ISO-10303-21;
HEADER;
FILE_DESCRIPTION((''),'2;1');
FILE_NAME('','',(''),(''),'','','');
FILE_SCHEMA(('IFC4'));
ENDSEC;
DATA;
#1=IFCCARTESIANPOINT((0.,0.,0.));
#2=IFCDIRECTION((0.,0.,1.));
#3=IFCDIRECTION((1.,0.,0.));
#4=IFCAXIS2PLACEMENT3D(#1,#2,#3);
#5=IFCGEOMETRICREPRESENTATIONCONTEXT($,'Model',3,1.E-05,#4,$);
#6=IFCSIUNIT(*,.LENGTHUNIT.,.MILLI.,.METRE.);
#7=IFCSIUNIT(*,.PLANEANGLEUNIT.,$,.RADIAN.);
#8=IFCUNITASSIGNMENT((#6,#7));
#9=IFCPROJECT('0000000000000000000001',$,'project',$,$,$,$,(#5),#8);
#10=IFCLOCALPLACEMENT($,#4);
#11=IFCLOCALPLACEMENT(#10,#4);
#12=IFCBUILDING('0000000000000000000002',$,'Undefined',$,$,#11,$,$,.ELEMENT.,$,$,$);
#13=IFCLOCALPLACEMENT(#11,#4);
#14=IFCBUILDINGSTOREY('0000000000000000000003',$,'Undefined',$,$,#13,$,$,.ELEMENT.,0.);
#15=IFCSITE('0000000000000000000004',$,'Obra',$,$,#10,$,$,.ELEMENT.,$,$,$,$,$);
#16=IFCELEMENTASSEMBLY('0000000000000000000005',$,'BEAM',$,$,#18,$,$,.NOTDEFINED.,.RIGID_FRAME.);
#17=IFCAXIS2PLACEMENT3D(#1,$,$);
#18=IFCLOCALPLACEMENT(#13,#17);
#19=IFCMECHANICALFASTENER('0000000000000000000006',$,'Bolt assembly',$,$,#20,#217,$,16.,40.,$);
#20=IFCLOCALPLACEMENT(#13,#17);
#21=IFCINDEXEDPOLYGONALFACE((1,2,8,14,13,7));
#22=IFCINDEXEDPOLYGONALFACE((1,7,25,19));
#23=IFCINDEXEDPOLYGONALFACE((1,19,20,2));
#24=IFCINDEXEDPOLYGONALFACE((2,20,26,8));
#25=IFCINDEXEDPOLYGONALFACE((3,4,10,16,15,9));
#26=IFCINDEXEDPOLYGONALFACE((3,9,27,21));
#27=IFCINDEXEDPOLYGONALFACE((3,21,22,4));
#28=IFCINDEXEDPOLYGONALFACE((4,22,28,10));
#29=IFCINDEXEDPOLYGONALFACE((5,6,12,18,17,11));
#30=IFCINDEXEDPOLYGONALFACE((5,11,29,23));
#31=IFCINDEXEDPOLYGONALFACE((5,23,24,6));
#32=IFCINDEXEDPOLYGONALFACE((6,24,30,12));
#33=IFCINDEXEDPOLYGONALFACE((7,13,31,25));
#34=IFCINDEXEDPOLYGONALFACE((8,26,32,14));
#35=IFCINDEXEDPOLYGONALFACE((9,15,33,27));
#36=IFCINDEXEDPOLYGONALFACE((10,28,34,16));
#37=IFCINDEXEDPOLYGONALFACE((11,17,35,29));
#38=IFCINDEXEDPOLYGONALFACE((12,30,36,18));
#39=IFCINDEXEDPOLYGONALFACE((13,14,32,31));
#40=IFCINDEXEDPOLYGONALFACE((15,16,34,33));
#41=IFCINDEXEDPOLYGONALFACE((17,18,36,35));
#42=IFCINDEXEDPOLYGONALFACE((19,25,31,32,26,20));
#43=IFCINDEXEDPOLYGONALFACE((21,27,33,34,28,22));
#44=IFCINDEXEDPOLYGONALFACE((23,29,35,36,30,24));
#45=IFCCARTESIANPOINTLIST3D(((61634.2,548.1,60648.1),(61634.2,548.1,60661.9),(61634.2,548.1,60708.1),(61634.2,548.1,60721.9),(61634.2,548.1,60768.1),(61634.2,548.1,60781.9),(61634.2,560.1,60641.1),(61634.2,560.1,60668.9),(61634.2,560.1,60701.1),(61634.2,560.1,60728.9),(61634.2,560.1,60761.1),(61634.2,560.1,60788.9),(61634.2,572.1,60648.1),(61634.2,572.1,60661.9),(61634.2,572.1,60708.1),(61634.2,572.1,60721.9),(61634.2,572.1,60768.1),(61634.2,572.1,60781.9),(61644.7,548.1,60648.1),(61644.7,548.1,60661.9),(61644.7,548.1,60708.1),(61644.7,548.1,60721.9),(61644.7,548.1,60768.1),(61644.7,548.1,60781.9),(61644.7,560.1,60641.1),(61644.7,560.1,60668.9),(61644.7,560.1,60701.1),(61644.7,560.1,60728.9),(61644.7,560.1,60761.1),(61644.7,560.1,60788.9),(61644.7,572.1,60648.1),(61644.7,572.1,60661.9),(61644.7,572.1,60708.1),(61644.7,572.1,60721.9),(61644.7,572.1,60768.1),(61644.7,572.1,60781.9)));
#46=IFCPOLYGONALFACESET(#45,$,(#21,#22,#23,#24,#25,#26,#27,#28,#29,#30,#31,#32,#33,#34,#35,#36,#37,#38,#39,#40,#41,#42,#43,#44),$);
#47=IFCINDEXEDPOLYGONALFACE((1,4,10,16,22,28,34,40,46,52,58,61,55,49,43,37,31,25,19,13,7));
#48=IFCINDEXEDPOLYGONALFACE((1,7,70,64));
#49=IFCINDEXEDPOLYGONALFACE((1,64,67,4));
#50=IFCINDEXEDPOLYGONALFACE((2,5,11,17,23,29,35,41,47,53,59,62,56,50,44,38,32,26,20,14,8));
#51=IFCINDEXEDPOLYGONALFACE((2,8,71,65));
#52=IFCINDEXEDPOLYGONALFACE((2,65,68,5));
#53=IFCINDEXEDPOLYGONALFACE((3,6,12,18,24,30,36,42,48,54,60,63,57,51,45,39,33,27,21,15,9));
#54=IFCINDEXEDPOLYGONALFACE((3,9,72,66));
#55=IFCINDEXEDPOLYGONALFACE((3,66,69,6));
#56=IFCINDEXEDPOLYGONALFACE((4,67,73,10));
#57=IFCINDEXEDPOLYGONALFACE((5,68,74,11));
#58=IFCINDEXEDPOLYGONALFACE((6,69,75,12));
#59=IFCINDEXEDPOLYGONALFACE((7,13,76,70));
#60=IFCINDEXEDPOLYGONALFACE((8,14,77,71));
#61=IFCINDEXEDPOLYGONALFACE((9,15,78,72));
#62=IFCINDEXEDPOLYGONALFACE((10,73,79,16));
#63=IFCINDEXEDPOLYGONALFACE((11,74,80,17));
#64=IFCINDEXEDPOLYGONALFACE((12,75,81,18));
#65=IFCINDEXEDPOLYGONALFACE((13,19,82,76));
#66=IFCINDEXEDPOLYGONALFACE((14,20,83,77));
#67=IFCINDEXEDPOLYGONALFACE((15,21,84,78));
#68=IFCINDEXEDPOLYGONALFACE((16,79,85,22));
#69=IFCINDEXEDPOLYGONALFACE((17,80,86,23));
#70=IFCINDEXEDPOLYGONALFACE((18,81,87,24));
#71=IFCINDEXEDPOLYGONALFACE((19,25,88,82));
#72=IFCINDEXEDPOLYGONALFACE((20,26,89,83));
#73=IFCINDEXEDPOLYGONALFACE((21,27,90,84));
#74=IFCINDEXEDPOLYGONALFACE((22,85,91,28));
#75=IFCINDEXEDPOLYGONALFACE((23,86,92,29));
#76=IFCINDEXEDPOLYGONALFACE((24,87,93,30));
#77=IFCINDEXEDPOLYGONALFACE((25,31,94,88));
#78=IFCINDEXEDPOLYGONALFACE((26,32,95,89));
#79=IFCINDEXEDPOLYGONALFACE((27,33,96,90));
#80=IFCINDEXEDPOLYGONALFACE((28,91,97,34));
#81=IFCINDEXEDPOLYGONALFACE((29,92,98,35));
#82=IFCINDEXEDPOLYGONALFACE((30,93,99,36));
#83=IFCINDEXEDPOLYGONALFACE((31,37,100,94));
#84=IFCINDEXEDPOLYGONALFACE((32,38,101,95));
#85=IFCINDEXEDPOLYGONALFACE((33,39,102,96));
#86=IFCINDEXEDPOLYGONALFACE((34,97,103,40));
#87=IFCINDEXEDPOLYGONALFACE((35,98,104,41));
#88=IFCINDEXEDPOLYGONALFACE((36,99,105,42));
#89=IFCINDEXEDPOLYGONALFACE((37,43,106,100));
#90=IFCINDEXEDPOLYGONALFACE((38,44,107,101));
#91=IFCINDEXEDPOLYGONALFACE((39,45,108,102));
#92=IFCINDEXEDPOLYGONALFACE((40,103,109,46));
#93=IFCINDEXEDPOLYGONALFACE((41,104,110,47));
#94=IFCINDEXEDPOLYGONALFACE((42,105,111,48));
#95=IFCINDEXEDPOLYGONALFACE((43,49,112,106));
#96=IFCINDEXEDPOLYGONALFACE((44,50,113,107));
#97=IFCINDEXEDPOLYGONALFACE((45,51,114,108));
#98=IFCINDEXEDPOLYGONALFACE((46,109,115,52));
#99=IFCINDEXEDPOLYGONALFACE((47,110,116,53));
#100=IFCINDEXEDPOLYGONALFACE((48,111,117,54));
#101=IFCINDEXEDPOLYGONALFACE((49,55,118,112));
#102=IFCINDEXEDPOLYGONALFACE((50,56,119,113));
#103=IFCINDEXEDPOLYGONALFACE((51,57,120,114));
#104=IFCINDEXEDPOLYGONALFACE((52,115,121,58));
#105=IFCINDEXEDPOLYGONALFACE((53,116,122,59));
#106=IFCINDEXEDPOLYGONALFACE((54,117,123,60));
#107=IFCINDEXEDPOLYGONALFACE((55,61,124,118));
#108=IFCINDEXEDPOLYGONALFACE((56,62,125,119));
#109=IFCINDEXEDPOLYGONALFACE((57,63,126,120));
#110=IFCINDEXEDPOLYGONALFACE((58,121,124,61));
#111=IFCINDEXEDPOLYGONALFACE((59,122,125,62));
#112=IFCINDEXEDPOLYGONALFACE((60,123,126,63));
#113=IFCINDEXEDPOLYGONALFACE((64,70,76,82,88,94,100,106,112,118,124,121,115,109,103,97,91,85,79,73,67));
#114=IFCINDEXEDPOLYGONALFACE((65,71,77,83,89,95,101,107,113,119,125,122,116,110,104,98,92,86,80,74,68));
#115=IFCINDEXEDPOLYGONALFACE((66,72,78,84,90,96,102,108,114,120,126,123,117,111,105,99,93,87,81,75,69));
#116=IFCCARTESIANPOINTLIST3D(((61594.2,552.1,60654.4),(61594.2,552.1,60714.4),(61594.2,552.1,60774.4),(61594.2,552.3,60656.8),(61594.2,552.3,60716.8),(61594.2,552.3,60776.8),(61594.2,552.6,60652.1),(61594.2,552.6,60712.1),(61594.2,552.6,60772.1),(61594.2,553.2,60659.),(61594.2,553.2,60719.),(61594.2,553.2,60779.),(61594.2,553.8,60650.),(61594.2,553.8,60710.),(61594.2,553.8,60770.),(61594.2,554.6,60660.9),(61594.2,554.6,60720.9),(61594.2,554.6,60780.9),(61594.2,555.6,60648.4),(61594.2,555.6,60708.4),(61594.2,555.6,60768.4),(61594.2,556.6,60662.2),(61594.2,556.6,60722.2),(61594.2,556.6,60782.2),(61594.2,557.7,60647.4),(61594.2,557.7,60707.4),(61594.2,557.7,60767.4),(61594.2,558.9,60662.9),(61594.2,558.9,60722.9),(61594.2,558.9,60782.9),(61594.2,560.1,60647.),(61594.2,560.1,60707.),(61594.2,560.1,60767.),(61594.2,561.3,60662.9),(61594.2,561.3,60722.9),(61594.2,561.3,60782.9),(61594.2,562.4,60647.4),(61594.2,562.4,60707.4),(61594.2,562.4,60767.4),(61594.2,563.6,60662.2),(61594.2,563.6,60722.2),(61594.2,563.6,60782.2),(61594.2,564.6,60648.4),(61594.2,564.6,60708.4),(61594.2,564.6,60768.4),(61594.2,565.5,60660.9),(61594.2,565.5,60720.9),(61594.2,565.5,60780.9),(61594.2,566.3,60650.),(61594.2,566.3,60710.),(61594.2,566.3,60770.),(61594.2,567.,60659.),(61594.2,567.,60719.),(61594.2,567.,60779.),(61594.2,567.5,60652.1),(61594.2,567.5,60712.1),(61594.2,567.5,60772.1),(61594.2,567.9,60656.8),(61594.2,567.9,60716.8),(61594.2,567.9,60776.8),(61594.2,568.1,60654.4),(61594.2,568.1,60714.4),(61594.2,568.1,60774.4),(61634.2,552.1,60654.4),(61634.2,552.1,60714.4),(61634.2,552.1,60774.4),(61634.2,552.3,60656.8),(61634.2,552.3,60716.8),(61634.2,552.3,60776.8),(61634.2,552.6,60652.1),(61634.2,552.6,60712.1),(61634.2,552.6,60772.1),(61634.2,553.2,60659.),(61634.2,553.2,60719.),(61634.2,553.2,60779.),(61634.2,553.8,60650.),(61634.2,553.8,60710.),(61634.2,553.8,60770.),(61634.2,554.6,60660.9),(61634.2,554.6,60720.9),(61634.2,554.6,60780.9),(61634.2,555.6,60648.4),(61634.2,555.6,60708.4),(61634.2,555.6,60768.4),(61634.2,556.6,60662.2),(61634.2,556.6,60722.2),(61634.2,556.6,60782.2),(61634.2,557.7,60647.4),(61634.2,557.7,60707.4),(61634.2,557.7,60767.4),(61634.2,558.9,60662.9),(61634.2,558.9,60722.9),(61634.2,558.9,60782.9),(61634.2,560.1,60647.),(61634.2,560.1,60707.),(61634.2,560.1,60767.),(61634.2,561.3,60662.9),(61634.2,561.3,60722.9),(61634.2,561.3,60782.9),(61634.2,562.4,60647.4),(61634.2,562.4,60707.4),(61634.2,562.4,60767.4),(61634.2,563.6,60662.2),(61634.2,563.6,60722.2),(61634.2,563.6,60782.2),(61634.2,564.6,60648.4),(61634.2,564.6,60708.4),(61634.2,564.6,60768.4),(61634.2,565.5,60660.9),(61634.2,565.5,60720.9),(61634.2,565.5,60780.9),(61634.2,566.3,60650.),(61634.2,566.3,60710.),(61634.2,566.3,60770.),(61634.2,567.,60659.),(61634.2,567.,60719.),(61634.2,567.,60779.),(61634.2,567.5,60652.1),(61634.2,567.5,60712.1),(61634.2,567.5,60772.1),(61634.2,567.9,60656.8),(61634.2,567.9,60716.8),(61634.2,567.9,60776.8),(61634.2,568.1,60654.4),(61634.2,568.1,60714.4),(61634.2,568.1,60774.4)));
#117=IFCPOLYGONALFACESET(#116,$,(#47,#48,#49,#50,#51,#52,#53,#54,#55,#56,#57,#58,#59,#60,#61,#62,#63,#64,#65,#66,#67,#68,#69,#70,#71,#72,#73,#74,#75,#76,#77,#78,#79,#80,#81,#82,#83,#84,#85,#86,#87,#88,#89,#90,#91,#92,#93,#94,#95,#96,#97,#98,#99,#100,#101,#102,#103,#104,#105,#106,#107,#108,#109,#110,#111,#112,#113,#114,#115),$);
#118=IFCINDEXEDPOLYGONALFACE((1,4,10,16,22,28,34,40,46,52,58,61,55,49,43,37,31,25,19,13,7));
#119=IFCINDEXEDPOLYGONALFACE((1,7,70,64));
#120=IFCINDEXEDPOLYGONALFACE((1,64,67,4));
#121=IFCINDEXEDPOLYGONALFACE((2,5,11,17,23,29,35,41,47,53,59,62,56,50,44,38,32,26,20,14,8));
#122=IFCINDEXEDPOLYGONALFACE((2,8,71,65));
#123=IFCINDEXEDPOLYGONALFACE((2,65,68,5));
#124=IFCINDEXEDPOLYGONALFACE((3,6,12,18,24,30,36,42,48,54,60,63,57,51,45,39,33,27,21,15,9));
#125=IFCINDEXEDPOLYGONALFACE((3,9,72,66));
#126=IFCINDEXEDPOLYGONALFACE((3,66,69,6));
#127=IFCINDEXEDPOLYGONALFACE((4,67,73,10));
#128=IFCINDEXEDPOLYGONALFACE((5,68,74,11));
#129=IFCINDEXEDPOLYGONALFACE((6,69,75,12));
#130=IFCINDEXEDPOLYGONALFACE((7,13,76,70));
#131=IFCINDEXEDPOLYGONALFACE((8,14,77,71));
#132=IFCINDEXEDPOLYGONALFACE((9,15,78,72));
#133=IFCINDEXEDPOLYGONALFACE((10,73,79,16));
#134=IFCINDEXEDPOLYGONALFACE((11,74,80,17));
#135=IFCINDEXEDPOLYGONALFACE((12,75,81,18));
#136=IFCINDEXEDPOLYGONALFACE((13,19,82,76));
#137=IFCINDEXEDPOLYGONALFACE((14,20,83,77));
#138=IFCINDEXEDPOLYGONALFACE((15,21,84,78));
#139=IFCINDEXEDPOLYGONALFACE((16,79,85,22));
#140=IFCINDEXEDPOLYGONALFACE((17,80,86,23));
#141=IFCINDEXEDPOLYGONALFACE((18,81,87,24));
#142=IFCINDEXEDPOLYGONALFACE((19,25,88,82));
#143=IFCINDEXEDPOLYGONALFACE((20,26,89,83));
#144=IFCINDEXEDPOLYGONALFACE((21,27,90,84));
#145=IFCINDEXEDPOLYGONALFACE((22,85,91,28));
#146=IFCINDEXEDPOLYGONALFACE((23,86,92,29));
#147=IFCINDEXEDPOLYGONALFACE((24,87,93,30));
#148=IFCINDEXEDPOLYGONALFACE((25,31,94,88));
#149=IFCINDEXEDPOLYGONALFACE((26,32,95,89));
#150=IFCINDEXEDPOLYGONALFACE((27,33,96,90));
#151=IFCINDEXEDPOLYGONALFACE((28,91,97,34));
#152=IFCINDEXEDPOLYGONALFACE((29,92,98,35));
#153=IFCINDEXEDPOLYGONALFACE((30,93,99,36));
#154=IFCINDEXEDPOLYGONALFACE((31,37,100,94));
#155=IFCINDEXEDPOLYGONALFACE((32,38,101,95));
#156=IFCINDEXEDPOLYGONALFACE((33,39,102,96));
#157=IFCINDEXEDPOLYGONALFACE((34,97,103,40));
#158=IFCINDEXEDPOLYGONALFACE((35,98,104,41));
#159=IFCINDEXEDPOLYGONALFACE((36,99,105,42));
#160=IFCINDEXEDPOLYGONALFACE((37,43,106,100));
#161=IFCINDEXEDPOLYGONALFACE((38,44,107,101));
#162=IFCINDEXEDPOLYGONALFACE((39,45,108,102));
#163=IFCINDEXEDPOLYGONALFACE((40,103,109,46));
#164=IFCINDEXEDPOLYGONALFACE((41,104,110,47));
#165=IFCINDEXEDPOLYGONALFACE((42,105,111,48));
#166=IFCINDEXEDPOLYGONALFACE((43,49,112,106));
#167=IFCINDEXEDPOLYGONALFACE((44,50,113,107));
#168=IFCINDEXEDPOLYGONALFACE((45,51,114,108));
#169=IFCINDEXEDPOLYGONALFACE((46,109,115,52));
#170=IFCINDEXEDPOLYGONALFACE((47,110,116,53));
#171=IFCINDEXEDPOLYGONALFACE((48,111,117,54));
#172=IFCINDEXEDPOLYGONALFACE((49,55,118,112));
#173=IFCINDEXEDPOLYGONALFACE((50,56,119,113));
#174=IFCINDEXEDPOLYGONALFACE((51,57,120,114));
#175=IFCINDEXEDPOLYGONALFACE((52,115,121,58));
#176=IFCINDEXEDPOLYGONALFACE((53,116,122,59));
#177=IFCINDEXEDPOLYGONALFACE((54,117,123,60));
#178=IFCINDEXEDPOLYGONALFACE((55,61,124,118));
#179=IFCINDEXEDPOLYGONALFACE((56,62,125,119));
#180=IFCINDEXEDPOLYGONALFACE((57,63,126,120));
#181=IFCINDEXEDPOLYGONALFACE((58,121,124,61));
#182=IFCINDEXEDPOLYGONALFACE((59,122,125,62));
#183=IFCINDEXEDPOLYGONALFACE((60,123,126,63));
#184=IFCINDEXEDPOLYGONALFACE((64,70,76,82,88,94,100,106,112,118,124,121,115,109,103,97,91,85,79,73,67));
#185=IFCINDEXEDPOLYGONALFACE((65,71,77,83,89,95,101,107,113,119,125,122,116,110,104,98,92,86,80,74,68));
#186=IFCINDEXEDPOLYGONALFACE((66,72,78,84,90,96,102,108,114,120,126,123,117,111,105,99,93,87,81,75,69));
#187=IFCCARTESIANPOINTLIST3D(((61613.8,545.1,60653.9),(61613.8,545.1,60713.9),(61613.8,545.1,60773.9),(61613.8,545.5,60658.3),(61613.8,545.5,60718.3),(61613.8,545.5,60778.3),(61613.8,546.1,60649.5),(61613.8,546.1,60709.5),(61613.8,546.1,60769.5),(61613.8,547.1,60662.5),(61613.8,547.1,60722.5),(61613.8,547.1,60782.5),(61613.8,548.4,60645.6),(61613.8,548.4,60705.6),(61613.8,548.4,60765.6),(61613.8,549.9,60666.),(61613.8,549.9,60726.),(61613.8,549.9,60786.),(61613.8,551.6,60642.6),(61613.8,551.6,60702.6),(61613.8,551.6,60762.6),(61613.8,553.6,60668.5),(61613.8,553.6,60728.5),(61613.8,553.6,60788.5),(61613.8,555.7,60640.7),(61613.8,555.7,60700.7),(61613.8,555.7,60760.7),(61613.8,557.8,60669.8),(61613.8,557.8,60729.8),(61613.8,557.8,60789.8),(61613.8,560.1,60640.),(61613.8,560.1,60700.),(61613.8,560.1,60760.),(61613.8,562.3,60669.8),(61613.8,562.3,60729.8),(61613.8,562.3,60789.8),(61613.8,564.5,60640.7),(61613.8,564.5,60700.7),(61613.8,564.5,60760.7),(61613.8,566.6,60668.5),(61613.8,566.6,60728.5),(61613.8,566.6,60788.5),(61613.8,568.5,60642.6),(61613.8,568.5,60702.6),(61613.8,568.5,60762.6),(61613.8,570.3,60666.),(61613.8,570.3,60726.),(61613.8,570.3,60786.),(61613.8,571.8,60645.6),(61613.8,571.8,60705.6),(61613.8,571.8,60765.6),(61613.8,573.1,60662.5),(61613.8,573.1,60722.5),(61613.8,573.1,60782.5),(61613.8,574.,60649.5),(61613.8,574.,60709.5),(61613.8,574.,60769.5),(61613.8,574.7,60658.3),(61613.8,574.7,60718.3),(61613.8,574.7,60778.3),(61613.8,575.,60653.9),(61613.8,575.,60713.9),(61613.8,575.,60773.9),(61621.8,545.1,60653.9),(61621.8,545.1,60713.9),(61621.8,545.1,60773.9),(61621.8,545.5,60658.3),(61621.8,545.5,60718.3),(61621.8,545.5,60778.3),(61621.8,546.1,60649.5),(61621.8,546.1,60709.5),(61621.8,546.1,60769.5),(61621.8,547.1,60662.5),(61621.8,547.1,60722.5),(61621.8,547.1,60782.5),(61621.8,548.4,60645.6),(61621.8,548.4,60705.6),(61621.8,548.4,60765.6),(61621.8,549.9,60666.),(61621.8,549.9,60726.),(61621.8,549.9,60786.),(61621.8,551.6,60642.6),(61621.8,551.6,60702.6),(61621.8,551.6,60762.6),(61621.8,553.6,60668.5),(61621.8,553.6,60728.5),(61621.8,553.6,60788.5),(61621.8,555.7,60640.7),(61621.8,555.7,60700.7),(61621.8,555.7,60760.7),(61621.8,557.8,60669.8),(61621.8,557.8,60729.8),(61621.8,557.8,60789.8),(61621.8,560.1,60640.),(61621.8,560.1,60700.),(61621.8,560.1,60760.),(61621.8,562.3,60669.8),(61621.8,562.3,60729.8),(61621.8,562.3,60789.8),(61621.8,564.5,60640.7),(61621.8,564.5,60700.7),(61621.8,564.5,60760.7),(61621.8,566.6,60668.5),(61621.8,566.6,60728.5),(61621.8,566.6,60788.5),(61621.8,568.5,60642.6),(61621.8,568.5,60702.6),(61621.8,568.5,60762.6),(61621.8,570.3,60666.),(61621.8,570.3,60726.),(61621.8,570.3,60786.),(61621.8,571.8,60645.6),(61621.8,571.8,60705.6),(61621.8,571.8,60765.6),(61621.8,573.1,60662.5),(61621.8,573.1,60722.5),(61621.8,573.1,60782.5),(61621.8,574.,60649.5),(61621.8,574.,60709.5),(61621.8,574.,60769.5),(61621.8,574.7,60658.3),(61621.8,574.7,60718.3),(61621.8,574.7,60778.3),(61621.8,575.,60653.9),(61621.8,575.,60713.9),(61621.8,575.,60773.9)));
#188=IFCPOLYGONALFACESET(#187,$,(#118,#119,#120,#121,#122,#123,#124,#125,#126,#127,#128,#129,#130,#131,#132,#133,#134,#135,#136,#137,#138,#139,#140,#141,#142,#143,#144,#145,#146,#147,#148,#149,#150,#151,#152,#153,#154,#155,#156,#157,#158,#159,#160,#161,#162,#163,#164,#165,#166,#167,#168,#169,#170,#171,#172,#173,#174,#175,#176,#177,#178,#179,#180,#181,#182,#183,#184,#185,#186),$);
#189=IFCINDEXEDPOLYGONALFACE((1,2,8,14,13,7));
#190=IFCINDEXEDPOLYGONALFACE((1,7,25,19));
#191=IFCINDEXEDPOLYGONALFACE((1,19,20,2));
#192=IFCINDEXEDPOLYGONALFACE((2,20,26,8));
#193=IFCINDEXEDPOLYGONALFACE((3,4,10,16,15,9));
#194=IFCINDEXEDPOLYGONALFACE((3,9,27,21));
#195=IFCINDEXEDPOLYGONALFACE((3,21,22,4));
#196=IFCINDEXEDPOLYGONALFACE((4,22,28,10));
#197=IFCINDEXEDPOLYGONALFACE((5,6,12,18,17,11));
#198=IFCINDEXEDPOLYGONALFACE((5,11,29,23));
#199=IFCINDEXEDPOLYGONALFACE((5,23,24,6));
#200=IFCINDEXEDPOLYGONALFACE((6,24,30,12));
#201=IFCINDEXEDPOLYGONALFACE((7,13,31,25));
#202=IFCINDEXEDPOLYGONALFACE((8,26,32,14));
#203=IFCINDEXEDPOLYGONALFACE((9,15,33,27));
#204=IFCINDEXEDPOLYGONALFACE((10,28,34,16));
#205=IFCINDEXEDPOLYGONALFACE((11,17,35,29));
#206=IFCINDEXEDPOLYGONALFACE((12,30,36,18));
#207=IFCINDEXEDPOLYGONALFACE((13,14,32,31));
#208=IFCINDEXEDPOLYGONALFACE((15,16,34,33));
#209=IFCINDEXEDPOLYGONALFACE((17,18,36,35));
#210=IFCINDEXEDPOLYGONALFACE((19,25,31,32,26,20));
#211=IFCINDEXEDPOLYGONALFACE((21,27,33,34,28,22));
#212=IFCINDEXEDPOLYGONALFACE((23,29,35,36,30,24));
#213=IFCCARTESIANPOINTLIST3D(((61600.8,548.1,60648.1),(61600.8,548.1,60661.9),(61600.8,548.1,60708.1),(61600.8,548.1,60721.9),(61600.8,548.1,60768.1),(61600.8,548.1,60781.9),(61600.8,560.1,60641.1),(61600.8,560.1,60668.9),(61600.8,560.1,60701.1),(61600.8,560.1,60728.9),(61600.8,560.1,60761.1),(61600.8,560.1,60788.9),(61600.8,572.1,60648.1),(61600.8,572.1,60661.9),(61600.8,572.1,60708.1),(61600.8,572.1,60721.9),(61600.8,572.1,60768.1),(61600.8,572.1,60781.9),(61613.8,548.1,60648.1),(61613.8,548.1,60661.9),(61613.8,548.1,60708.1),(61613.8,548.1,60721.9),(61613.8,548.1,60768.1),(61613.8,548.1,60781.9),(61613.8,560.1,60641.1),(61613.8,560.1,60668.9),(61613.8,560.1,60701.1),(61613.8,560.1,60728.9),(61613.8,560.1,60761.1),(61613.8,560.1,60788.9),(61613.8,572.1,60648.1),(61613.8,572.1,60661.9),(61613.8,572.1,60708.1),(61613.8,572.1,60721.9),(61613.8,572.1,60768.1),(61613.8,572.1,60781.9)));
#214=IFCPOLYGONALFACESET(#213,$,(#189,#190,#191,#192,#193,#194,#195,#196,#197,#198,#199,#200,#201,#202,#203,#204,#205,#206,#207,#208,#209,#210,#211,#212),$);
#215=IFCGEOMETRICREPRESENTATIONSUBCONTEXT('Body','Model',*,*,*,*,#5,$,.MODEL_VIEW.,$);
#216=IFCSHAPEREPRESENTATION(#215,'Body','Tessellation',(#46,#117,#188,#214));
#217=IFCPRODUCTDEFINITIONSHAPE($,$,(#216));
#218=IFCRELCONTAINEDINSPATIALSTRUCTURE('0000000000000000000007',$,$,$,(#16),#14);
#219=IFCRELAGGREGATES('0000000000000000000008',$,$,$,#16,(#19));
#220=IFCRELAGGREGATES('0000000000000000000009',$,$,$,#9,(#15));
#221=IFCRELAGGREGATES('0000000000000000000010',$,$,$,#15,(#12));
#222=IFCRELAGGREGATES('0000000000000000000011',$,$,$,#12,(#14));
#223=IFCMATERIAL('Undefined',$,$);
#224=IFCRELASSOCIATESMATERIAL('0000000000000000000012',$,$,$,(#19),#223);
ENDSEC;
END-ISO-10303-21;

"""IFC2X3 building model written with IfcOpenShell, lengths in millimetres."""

from ifc_helpers import new_model, si_unit, frame, origin_with_axes, origin_2d_with_axis, place, context, subcontext, project, spatial, polyline, circle, outline, extrude, source, transform, mapped, material, element, aggregate, save


model = new_model("IFC2X3")

# Units and contexts
model_context = context("Model", 3, precision=1e-05, world=origin_with_axes())
body_context = subcontext(model_context, "Body", "Model", "MODEL_VIEW")
ifc_project = project(units=[si_unit("LENGTHUNIT", "METRE", prefix="MILLI"), si_unit("PLANEANGLEUNIT", "RADIAN")], contexts=[model_context])

# Site, building, storey
site_placement = place(None, origin_with_axes())
site = spatial("IfcSite", under=ifc_project, at=site_placement, Name="Obra", CompositionType="ELEMENT")
building_placement = place(site_placement, origin_with_axes())
building = spatial("IfcBuilding", under=site, at=building_placement, Name="Undefined", CompositionType="ELEMENT")
storey_placement = place(building_placement, origin_with_axes())
storey = spatial("IfcBuildingStorey", under=building, at=storey_placement, Name="Undefined", CompositionType="ELEMENT", Elevation=0.0)

# Element assembly
ifc_material_1 = material(Name="Undefined")
assembly_1_placement = place(storey_placement, origin_with_axes())
assembly_1 = element("IfcElementAssembly", 1, at=assembly_1_placement, inside=storey, Name="BEAM", AssemblyPlace="NOTDEFINED", PredefinedType="RIGID_FRAME")

# Mechanical fastener
shared_shape_1 = source(origin_with_axes(), body_context, "Body", "SweptSolid", [
    extrude(outline(polyline([(13.9, 0.0), (6.9, 12.0), (-6.9, 12.0), (-13.9, 0.0), (-6.9, -12.0), (6.9, -12.0), (13.9, 0.0)])), frame((0.0, -19.7, 0.0), z_axis=(0.0, 1.0, 0.0), x_axis=(1.0, 0.0, 0.0)), (0.0, 0.0, 1.0), 10.6),
    extrude(circle(Radius=8.0, at=origin_2d_with_axis()), frame((0.0, -9.1, 0.0), z_axis=(0.0, 1.0, 0.0), x_axis=(1.0, 0.0, 0.0)), (0.0, 0.0, 1.0), 40.0),
    extrude(circle(Radius=15.0, at=origin_2d_with_axis()), frame((0.0, 3.3, 0.0), z_axis=(0.0, 1.0, 0.0), x_axis=(1.0, 0.0, 0.0)), (0.0, 0.0, 1.0), 8.0),
    extrude(outline(polyline([(13.9, 0.0), (6.9, 12.0), (-6.9, 12.0), (-13.9, 0.0), (-6.9, -12.0), (6.9, -12.0), (13.9, 0.0)])), frame((0.0, 11.3, 0.0), z_axis=(0.0, 1.0, 0.0), x_axis=(1.0, 0.0, 0.0)), (0.0, 0.0, 1.0), 13.0),
])
mechanical_fastener_1_placement = place(assembly_1_placement, frame((61625.1, 510.1, 60835.0), z_axis=(-0.000002, 1.0, 0.0), x_axis=(0.0, 0.0, -1.0)))
mechanical_fastener_1 = element("IfcMechanicalFastener", 2, at=mechanical_fastener_1_placement, material=ifc_material_1, Name="Bolt assembly", NominalDiameter=16.0, NominalLength=40.0, context=body_context, shape_type="MappedRepresentation", body=[
    mapped(shared_shape_1, transform((60.0, 0.0, 50.0))),
    mapped(shared_shape_1, transform((120.0, 0.0, 50.0))),
    mapped(shared_shape_1, transform((180.0, 0.0, 50.0))),
])
aggregate(assembly_1, [mechanical_fastener_1])

save(model, "model.ifc")
